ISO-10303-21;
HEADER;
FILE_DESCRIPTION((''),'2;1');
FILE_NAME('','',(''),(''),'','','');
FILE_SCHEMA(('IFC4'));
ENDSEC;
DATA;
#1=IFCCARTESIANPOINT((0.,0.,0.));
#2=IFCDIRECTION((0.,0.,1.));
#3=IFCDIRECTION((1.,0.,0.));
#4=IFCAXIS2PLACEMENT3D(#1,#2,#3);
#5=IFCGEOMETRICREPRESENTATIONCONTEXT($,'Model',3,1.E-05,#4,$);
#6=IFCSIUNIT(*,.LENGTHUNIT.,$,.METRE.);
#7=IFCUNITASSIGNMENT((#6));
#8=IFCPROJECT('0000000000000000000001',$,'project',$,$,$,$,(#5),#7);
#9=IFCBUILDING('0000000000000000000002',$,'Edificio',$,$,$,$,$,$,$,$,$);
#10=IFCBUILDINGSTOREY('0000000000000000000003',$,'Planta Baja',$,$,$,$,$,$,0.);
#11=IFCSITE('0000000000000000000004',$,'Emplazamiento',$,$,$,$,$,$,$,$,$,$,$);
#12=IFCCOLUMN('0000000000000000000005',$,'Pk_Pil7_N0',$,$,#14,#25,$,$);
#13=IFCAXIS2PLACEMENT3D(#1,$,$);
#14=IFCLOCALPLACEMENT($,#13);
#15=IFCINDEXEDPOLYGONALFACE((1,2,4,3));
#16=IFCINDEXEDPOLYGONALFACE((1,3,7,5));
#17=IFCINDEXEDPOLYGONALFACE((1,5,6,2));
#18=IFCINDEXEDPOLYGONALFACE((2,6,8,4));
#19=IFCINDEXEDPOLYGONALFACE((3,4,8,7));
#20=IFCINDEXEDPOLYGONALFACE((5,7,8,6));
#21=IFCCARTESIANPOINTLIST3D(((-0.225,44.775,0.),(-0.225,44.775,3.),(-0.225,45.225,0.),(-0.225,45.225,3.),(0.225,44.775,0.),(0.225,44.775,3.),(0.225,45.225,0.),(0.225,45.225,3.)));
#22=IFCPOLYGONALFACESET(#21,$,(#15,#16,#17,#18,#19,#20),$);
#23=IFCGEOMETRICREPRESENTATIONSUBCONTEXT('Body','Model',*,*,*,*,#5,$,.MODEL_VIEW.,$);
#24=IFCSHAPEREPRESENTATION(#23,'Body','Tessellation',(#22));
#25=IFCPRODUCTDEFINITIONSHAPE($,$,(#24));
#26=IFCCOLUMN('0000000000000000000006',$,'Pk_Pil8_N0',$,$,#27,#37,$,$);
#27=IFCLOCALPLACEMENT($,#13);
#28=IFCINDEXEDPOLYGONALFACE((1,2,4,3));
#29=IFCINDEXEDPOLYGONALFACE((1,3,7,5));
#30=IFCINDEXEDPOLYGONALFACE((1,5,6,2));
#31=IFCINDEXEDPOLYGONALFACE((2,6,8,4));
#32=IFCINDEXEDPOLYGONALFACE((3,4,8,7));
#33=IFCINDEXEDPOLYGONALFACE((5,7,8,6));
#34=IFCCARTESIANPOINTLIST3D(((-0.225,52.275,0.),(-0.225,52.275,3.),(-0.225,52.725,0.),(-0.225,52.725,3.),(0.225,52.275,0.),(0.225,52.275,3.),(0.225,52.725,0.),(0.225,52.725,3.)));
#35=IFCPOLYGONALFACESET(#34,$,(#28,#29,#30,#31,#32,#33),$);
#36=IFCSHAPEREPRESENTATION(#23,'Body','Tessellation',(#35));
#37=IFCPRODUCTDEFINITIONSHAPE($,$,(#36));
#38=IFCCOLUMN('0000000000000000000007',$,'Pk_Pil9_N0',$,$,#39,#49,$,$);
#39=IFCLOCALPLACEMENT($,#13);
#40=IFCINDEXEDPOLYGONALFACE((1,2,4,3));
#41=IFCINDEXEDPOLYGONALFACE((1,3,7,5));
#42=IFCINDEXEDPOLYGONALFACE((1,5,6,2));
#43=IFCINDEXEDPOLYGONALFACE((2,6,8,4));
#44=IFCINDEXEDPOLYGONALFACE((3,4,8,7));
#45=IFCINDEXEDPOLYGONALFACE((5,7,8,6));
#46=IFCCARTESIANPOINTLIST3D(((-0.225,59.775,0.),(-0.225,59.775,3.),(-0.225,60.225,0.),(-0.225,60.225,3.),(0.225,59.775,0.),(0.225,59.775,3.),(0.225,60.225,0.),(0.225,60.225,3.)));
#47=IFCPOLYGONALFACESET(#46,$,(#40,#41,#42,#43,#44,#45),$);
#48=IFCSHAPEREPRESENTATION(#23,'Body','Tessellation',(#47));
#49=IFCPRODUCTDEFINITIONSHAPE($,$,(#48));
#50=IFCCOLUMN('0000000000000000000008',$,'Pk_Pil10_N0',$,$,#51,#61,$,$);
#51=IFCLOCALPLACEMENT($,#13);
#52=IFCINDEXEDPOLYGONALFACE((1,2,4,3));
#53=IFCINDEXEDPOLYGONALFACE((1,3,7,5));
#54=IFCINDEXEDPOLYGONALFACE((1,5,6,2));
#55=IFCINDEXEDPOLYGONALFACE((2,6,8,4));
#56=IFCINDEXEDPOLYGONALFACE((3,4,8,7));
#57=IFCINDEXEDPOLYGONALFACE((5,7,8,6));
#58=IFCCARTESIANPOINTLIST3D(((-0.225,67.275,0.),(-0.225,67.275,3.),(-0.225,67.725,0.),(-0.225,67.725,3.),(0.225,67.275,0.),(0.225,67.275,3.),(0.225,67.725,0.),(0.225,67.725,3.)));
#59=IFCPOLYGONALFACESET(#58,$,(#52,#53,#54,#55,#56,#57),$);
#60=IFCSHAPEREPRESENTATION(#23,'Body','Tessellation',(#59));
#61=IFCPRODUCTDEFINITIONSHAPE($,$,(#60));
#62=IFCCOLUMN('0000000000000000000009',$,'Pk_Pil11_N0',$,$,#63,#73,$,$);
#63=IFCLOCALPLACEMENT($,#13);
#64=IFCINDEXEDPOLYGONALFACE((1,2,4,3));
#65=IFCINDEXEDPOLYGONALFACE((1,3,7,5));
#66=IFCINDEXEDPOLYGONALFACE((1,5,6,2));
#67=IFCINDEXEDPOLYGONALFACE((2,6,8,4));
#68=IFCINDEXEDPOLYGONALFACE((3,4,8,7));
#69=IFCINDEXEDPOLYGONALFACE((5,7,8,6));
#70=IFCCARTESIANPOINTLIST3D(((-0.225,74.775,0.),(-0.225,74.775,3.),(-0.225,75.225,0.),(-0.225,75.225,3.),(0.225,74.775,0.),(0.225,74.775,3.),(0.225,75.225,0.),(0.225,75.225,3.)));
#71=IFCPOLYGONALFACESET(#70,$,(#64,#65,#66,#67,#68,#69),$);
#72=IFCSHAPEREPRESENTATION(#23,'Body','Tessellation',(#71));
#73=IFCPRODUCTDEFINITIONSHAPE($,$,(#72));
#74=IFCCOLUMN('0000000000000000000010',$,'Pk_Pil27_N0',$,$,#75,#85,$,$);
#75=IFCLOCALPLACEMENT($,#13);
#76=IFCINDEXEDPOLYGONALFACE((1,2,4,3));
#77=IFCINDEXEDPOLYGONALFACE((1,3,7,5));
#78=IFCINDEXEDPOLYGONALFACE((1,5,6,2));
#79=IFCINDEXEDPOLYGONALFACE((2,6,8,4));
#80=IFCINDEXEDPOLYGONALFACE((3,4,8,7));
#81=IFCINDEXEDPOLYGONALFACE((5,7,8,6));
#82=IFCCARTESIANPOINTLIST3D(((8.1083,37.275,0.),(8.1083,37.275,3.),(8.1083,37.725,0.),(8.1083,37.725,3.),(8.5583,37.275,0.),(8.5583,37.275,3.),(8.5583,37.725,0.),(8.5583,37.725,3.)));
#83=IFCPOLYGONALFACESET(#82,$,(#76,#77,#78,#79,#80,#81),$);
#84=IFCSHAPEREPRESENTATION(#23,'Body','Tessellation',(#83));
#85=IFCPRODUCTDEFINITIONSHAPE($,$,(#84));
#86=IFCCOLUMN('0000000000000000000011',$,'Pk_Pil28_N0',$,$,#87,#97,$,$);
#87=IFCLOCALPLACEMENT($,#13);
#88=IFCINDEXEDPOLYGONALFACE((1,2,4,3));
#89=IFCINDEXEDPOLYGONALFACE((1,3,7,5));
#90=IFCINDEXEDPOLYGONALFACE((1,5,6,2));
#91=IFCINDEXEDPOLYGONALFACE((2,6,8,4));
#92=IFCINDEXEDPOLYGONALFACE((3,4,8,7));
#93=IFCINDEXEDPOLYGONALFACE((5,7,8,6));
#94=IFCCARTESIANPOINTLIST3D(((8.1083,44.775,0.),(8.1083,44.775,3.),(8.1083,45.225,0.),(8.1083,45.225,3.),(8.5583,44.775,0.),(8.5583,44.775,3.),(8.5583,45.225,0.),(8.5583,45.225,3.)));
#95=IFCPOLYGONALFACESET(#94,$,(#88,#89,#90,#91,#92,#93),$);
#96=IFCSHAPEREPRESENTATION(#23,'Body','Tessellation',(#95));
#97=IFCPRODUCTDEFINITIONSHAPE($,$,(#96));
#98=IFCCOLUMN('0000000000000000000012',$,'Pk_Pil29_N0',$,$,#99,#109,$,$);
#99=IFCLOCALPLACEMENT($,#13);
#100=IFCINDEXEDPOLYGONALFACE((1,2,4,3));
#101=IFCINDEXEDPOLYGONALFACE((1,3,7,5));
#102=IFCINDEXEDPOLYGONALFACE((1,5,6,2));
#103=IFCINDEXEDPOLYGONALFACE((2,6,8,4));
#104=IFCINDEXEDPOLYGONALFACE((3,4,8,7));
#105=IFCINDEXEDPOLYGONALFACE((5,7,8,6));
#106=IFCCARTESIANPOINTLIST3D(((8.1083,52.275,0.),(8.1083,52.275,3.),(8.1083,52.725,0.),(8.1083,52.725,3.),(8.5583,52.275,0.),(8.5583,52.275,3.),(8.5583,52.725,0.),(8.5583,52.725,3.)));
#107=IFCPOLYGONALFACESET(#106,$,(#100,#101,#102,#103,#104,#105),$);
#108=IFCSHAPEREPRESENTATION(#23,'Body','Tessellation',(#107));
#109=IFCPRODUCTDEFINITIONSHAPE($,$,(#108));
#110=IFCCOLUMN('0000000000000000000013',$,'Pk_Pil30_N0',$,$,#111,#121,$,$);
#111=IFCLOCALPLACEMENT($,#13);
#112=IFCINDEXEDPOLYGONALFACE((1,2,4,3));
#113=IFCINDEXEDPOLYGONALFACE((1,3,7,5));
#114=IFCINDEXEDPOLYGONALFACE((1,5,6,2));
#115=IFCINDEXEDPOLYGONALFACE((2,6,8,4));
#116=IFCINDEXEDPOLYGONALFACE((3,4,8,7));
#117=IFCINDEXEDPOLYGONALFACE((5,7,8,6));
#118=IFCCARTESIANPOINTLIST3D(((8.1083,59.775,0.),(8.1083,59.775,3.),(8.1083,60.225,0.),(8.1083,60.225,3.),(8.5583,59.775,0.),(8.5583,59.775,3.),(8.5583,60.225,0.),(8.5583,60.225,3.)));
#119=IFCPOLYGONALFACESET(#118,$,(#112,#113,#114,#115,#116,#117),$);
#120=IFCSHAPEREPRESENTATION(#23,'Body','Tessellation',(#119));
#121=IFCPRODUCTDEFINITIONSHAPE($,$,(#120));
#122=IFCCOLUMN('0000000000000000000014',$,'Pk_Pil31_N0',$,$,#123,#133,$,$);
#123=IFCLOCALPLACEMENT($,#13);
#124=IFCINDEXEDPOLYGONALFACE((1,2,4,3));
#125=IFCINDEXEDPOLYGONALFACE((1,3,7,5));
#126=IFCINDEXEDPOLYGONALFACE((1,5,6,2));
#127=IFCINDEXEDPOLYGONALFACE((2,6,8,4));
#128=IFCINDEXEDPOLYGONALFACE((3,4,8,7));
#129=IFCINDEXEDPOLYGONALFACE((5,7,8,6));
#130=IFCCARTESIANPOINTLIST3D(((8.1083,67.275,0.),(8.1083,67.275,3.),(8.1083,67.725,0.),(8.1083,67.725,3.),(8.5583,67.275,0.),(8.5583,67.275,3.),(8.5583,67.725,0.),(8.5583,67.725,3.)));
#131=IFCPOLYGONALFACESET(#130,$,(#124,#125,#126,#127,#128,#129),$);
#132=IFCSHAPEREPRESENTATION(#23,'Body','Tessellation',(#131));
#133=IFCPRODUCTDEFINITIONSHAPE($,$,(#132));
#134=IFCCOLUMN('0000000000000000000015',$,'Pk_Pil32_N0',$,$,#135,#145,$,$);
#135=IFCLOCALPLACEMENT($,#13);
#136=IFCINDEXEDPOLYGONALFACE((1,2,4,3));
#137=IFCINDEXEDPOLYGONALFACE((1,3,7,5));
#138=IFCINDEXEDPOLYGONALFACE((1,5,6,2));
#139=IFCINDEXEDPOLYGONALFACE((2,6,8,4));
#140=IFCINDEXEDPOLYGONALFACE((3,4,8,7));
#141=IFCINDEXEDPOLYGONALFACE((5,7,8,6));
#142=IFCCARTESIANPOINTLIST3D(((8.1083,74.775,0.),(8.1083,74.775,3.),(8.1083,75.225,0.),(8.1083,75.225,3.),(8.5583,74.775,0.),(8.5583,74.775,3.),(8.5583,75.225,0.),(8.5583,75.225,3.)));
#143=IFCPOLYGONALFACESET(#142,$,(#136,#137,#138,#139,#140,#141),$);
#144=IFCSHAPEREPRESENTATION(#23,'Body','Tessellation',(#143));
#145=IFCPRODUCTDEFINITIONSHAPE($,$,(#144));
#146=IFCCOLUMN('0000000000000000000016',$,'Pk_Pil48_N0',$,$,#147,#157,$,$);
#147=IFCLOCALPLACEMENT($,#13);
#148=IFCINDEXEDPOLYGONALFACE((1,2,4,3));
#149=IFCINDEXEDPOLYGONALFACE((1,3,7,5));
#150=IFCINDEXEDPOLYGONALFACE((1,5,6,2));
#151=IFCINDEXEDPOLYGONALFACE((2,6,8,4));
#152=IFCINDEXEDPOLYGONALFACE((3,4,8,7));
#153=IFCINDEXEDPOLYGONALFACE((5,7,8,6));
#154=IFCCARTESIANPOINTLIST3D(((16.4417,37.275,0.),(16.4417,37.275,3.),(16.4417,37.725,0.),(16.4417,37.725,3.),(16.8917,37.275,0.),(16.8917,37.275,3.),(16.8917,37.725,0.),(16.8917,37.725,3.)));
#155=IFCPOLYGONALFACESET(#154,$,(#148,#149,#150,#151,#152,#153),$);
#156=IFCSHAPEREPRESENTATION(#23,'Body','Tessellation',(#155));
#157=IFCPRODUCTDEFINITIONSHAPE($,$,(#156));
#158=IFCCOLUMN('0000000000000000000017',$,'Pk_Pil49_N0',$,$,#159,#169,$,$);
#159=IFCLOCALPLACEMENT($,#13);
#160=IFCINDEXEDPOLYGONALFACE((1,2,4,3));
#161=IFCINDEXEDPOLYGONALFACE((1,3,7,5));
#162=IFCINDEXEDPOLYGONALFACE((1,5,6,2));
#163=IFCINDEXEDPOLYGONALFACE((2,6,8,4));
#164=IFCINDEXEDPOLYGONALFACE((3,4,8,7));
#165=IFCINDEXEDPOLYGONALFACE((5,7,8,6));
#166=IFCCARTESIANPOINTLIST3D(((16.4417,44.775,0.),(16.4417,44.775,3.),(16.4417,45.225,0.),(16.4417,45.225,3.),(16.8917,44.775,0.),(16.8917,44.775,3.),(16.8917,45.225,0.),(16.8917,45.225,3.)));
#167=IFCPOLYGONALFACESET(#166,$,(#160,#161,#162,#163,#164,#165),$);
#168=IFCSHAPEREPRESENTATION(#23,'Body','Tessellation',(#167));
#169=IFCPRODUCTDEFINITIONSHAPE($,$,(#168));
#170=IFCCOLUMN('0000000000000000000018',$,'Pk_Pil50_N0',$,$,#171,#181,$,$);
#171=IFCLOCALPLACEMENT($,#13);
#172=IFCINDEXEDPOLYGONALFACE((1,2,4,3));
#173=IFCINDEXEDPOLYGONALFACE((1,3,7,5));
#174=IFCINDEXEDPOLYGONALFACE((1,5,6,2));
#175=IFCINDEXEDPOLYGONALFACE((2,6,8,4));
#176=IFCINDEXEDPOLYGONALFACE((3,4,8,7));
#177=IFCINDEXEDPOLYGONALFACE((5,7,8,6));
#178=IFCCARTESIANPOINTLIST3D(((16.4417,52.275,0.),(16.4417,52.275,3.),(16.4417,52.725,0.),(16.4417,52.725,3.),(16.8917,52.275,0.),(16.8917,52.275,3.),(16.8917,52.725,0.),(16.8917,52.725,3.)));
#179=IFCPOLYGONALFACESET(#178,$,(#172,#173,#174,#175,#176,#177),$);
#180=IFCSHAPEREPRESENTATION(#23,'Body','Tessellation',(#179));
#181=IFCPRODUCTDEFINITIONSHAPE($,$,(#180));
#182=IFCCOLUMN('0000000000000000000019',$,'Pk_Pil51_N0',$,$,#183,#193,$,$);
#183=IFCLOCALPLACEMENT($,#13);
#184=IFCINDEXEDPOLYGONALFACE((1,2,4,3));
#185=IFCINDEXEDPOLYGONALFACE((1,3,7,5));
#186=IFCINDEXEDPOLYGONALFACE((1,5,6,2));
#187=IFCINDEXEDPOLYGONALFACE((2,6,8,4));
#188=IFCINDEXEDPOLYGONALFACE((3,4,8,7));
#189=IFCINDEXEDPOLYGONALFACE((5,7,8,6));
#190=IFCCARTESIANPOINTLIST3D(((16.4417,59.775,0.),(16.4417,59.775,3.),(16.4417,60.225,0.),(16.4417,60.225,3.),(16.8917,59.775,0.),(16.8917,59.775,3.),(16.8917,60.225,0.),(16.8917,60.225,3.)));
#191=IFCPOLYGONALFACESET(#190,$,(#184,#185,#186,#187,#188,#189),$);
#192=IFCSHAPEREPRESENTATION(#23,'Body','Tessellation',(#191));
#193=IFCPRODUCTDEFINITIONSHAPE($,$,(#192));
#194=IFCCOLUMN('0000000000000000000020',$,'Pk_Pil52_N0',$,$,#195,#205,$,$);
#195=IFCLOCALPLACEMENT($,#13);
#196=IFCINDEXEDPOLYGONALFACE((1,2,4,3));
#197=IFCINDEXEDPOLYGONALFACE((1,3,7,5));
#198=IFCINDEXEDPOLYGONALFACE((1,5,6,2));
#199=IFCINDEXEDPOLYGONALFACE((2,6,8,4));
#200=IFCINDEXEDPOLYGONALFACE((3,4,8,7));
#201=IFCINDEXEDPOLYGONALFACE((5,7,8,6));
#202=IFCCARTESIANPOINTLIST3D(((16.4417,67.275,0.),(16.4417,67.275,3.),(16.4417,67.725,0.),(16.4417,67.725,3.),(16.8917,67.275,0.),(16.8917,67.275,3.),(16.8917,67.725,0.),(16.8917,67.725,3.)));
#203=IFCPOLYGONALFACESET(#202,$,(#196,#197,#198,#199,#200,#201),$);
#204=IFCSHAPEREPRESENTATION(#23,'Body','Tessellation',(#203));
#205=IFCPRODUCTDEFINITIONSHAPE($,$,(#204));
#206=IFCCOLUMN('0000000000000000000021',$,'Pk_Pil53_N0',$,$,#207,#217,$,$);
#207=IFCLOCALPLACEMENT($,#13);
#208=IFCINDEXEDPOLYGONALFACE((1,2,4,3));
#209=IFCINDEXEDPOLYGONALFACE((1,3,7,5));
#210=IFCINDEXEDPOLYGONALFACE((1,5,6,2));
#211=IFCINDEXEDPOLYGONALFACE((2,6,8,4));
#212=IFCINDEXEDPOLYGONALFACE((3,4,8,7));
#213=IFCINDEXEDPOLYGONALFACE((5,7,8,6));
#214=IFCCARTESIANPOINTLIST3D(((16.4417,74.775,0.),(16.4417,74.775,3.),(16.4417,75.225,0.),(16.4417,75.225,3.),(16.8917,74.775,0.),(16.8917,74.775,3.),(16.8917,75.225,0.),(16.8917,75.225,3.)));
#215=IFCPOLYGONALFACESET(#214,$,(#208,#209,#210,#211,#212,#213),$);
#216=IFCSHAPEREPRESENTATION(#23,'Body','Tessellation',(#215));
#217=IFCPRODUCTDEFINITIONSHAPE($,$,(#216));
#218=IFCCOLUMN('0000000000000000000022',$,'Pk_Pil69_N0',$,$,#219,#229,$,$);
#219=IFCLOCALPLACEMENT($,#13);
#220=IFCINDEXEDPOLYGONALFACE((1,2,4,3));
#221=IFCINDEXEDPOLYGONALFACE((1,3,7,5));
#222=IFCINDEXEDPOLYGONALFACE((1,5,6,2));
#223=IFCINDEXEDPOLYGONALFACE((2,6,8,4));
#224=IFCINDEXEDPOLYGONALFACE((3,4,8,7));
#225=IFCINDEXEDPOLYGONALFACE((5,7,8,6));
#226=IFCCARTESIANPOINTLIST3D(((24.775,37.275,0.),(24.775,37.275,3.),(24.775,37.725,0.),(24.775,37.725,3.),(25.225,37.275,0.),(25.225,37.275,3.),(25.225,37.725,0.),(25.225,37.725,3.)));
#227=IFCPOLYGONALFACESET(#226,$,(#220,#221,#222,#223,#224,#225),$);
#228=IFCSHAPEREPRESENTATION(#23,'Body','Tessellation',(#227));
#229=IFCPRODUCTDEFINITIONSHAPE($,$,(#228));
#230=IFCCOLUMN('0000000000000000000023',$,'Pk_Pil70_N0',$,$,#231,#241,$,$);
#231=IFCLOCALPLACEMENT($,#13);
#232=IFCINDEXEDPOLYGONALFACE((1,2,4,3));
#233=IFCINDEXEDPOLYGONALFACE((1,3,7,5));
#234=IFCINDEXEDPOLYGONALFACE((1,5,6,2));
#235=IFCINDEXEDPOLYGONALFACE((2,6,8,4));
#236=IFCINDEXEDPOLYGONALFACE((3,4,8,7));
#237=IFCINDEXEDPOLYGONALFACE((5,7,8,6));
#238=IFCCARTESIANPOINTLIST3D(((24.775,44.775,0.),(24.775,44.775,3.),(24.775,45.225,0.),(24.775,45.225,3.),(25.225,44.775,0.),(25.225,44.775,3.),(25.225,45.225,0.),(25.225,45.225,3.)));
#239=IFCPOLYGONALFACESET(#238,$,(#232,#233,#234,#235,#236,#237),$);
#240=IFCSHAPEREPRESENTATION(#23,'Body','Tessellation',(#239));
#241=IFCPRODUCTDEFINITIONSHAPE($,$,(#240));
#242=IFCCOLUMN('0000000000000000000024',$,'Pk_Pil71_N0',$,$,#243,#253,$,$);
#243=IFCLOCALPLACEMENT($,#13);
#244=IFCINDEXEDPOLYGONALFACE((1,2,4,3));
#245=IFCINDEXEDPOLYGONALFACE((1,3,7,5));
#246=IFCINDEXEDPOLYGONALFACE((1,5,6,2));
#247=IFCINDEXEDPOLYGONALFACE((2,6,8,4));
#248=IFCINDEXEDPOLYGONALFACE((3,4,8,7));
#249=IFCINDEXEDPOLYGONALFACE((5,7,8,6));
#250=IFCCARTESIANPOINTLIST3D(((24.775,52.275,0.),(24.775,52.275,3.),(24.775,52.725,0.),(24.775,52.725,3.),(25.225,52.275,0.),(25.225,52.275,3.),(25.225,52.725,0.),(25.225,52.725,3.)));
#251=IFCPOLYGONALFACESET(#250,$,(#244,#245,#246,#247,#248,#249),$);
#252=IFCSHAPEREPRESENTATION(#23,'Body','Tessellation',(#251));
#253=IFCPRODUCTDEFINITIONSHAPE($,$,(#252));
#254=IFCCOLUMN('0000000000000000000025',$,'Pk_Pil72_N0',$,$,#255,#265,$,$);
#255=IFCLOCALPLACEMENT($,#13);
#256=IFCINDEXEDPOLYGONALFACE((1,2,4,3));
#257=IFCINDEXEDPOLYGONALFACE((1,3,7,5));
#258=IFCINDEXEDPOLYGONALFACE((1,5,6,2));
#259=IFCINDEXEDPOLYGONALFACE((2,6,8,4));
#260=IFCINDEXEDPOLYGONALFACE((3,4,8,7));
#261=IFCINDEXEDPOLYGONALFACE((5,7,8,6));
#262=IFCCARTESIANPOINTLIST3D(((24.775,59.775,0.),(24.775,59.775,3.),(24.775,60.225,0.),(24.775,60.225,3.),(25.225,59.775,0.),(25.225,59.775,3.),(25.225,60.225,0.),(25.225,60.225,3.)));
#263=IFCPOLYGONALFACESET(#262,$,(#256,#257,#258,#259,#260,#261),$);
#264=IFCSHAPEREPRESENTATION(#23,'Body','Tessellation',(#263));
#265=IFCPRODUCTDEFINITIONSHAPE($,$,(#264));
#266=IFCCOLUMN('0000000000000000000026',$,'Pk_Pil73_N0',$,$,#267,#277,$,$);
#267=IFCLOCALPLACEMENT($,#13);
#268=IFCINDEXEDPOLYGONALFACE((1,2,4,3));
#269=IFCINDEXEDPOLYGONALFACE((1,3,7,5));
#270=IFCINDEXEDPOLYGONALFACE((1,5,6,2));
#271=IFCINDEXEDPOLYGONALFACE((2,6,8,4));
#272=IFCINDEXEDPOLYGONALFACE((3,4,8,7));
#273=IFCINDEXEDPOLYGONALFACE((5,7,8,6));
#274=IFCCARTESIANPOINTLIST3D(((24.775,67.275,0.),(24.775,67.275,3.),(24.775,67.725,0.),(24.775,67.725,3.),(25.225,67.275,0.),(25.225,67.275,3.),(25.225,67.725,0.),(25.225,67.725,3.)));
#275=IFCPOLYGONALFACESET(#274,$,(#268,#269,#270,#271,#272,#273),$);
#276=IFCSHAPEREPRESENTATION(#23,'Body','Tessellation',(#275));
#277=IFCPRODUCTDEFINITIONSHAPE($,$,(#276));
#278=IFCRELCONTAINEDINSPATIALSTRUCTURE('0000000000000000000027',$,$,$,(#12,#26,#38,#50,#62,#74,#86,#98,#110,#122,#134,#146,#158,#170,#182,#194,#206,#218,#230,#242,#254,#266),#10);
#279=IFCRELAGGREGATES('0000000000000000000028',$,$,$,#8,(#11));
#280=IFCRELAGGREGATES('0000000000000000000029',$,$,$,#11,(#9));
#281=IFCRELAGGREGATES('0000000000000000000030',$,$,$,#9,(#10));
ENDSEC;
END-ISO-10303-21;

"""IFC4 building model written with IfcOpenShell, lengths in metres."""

from ifc_helpers import new_model, si_unit, frame, origin_with_axes, origin_2d, place, context, subcontext, project, spatial, rectangle, extrude, element, save


model = new_model("IFC4")

# Units and contexts
model_context = context("Model", 3, precision=1e-05, world=origin_with_axes())
body_context = subcontext(model_context, "Body", "Model", "MODEL_VIEW")
ifc_project = project(units=[si_unit("LENGTHUNIT", "METRE")], contexts=[model_context])

# Site, building, storey
site = spatial("IfcSite", under=ifc_project, Name="Emplazamiento")
building = spatial("IfcBuilding", under=site, Name="Edificio")
storey = spatial("IfcBuildingStorey", under=building, Name="Planta Baja", Elevation=0.0)

# Columns
for number, where, z_axis, x_axis, name in (
    (1, (0.0, 45.0, 0.0), (0.0, 0.0, 1.0), (1.0, 0.0, 0.0), "Pk_Pil7_N0"),
    (2, (0.0, 52.5, 0.0), (0.0, 0.0, 1.0), (1.0, 0.0, 0.0), "Pk_Pil8_N0"),
    (3, (0.0, 60.0, 0.0), (0.0, 0.0, 1.0), (1.0, 0.0, 0.0), "Pk_Pil9_N0"),
    (4, (0.0, 67.5, 0.0), (0.0, 0.0, 1.0), (1.0, 0.0, 0.0), "Pk_Pil10_N0"),
    (5, (0.0, 75.0, 0.0), (0.0, 0.0, 1.0), (1.0, 0.0, 0.0), "Pk_Pil11_N0"),
    (6, (8.3333, 37.5, 0.0), (0.0, 0.0, 1.0), (1.0, 0.0, 0.0), "Pk_Pil27_N0"),
    (7, (8.3333, 45.0, 0.0), (0.0, 0.0, 1.0), (1.0, 0.0, 0.0), "Pk_Pil28_N0"),
    (8, (8.3333, 52.5, 0.0), (0.0, 0.0, 1.0), (1.0, 0.0, 0.0), "Pk_Pil29_N0"),
    (9, (8.3333, 60.0, 0.0), (0.0, 0.0, 1.0), (1.0, 0.0, 0.0), "Pk_Pil30_N0"),
    (10, (8.3333, 67.5, 0.0), (0.0, 0.0, 1.0), (1.0, 0.0, 0.0), "Pk_Pil31_N0"),
    (11, (8.3333, 75.0, 0.0), (0.0, 0.0, 1.0), (1.0, 0.0, 0.0), "Pk_Pil32_N0"),
    (12, (16.6667, 37.5, 0.0), (0.0, 0.0, 1.0), (1.0, 0.0, 0.0), "Pk_Pil48_N0"),
    (13, (16.6667, 45.0, 0.0), (0.0, 0.0, 1.0), (1.0, 0.0, 0.0), "Pk_Pil49_N0"),
    (14, (16.6667, 52.5, 0.0), (0.0, 0.0, 1.0), (1.0, 0.0, 0.0), "Pk_Pil50_N0"),
    (15, (16.6667, 60.0, 0.0), (0.0, 0.0, 1.0), (1.0, 0.0, 0.0), "Pk_Pil51_N0"),
    (16, (16.6667, 67.5, 0.0), (0.0, 0.0, 1.0), (1.0, 0.0, 0.0), "Pk_Pil52_N0"),
    (17, (16.6667, 75.0, 0.0), (0.0, 0.0, 1.0), (1.0, 0.0, 0.0), "Pk_Pil53_N0"),
    (18, (25.0, 37.5, 0.0), (0.0, 0.0, 1.0), (1.0, 0.0, 0.0), "Pk_Pil69_N0"),
    (19, (25.0, 45.0, 0.0), (0.0, 0.0, 1.0), (1.0, 0.0, 0.0), "Pk_Pil70_N0"),
    (20, (25.0, 52.5, 0.0), (0.0, 0.0, 1.0), (1.0, 0.0, 0.0), "Pk_Pil71_N0"),
    (21, (25.0, 60.0, 0.0), (0.0, 0.0, 1.0), (1.0, 0.0, 0.0), "Pk_Pil72_N0"),
    (22, (25.0, 67.5, 0.0), (0.0, 0.0, 1.0), (1.0, 0.0, 0.0), "Pk_Pil73_N0"),
):
    element("IfcColumn", number, at=place(None, frame(where, z_axis=z_axis, x_axis=x_axis)), inside=storey, Name=name, context=body_context, shape_type="SweptSolid", body=[
        extrude(rectangle(XDim=0.45, YDim=0.45, at=origin_2d()), origin_with_axes(), (0.0, 0.0, 1.0), 3.0),
    ])

save(model, "model.ifc")
